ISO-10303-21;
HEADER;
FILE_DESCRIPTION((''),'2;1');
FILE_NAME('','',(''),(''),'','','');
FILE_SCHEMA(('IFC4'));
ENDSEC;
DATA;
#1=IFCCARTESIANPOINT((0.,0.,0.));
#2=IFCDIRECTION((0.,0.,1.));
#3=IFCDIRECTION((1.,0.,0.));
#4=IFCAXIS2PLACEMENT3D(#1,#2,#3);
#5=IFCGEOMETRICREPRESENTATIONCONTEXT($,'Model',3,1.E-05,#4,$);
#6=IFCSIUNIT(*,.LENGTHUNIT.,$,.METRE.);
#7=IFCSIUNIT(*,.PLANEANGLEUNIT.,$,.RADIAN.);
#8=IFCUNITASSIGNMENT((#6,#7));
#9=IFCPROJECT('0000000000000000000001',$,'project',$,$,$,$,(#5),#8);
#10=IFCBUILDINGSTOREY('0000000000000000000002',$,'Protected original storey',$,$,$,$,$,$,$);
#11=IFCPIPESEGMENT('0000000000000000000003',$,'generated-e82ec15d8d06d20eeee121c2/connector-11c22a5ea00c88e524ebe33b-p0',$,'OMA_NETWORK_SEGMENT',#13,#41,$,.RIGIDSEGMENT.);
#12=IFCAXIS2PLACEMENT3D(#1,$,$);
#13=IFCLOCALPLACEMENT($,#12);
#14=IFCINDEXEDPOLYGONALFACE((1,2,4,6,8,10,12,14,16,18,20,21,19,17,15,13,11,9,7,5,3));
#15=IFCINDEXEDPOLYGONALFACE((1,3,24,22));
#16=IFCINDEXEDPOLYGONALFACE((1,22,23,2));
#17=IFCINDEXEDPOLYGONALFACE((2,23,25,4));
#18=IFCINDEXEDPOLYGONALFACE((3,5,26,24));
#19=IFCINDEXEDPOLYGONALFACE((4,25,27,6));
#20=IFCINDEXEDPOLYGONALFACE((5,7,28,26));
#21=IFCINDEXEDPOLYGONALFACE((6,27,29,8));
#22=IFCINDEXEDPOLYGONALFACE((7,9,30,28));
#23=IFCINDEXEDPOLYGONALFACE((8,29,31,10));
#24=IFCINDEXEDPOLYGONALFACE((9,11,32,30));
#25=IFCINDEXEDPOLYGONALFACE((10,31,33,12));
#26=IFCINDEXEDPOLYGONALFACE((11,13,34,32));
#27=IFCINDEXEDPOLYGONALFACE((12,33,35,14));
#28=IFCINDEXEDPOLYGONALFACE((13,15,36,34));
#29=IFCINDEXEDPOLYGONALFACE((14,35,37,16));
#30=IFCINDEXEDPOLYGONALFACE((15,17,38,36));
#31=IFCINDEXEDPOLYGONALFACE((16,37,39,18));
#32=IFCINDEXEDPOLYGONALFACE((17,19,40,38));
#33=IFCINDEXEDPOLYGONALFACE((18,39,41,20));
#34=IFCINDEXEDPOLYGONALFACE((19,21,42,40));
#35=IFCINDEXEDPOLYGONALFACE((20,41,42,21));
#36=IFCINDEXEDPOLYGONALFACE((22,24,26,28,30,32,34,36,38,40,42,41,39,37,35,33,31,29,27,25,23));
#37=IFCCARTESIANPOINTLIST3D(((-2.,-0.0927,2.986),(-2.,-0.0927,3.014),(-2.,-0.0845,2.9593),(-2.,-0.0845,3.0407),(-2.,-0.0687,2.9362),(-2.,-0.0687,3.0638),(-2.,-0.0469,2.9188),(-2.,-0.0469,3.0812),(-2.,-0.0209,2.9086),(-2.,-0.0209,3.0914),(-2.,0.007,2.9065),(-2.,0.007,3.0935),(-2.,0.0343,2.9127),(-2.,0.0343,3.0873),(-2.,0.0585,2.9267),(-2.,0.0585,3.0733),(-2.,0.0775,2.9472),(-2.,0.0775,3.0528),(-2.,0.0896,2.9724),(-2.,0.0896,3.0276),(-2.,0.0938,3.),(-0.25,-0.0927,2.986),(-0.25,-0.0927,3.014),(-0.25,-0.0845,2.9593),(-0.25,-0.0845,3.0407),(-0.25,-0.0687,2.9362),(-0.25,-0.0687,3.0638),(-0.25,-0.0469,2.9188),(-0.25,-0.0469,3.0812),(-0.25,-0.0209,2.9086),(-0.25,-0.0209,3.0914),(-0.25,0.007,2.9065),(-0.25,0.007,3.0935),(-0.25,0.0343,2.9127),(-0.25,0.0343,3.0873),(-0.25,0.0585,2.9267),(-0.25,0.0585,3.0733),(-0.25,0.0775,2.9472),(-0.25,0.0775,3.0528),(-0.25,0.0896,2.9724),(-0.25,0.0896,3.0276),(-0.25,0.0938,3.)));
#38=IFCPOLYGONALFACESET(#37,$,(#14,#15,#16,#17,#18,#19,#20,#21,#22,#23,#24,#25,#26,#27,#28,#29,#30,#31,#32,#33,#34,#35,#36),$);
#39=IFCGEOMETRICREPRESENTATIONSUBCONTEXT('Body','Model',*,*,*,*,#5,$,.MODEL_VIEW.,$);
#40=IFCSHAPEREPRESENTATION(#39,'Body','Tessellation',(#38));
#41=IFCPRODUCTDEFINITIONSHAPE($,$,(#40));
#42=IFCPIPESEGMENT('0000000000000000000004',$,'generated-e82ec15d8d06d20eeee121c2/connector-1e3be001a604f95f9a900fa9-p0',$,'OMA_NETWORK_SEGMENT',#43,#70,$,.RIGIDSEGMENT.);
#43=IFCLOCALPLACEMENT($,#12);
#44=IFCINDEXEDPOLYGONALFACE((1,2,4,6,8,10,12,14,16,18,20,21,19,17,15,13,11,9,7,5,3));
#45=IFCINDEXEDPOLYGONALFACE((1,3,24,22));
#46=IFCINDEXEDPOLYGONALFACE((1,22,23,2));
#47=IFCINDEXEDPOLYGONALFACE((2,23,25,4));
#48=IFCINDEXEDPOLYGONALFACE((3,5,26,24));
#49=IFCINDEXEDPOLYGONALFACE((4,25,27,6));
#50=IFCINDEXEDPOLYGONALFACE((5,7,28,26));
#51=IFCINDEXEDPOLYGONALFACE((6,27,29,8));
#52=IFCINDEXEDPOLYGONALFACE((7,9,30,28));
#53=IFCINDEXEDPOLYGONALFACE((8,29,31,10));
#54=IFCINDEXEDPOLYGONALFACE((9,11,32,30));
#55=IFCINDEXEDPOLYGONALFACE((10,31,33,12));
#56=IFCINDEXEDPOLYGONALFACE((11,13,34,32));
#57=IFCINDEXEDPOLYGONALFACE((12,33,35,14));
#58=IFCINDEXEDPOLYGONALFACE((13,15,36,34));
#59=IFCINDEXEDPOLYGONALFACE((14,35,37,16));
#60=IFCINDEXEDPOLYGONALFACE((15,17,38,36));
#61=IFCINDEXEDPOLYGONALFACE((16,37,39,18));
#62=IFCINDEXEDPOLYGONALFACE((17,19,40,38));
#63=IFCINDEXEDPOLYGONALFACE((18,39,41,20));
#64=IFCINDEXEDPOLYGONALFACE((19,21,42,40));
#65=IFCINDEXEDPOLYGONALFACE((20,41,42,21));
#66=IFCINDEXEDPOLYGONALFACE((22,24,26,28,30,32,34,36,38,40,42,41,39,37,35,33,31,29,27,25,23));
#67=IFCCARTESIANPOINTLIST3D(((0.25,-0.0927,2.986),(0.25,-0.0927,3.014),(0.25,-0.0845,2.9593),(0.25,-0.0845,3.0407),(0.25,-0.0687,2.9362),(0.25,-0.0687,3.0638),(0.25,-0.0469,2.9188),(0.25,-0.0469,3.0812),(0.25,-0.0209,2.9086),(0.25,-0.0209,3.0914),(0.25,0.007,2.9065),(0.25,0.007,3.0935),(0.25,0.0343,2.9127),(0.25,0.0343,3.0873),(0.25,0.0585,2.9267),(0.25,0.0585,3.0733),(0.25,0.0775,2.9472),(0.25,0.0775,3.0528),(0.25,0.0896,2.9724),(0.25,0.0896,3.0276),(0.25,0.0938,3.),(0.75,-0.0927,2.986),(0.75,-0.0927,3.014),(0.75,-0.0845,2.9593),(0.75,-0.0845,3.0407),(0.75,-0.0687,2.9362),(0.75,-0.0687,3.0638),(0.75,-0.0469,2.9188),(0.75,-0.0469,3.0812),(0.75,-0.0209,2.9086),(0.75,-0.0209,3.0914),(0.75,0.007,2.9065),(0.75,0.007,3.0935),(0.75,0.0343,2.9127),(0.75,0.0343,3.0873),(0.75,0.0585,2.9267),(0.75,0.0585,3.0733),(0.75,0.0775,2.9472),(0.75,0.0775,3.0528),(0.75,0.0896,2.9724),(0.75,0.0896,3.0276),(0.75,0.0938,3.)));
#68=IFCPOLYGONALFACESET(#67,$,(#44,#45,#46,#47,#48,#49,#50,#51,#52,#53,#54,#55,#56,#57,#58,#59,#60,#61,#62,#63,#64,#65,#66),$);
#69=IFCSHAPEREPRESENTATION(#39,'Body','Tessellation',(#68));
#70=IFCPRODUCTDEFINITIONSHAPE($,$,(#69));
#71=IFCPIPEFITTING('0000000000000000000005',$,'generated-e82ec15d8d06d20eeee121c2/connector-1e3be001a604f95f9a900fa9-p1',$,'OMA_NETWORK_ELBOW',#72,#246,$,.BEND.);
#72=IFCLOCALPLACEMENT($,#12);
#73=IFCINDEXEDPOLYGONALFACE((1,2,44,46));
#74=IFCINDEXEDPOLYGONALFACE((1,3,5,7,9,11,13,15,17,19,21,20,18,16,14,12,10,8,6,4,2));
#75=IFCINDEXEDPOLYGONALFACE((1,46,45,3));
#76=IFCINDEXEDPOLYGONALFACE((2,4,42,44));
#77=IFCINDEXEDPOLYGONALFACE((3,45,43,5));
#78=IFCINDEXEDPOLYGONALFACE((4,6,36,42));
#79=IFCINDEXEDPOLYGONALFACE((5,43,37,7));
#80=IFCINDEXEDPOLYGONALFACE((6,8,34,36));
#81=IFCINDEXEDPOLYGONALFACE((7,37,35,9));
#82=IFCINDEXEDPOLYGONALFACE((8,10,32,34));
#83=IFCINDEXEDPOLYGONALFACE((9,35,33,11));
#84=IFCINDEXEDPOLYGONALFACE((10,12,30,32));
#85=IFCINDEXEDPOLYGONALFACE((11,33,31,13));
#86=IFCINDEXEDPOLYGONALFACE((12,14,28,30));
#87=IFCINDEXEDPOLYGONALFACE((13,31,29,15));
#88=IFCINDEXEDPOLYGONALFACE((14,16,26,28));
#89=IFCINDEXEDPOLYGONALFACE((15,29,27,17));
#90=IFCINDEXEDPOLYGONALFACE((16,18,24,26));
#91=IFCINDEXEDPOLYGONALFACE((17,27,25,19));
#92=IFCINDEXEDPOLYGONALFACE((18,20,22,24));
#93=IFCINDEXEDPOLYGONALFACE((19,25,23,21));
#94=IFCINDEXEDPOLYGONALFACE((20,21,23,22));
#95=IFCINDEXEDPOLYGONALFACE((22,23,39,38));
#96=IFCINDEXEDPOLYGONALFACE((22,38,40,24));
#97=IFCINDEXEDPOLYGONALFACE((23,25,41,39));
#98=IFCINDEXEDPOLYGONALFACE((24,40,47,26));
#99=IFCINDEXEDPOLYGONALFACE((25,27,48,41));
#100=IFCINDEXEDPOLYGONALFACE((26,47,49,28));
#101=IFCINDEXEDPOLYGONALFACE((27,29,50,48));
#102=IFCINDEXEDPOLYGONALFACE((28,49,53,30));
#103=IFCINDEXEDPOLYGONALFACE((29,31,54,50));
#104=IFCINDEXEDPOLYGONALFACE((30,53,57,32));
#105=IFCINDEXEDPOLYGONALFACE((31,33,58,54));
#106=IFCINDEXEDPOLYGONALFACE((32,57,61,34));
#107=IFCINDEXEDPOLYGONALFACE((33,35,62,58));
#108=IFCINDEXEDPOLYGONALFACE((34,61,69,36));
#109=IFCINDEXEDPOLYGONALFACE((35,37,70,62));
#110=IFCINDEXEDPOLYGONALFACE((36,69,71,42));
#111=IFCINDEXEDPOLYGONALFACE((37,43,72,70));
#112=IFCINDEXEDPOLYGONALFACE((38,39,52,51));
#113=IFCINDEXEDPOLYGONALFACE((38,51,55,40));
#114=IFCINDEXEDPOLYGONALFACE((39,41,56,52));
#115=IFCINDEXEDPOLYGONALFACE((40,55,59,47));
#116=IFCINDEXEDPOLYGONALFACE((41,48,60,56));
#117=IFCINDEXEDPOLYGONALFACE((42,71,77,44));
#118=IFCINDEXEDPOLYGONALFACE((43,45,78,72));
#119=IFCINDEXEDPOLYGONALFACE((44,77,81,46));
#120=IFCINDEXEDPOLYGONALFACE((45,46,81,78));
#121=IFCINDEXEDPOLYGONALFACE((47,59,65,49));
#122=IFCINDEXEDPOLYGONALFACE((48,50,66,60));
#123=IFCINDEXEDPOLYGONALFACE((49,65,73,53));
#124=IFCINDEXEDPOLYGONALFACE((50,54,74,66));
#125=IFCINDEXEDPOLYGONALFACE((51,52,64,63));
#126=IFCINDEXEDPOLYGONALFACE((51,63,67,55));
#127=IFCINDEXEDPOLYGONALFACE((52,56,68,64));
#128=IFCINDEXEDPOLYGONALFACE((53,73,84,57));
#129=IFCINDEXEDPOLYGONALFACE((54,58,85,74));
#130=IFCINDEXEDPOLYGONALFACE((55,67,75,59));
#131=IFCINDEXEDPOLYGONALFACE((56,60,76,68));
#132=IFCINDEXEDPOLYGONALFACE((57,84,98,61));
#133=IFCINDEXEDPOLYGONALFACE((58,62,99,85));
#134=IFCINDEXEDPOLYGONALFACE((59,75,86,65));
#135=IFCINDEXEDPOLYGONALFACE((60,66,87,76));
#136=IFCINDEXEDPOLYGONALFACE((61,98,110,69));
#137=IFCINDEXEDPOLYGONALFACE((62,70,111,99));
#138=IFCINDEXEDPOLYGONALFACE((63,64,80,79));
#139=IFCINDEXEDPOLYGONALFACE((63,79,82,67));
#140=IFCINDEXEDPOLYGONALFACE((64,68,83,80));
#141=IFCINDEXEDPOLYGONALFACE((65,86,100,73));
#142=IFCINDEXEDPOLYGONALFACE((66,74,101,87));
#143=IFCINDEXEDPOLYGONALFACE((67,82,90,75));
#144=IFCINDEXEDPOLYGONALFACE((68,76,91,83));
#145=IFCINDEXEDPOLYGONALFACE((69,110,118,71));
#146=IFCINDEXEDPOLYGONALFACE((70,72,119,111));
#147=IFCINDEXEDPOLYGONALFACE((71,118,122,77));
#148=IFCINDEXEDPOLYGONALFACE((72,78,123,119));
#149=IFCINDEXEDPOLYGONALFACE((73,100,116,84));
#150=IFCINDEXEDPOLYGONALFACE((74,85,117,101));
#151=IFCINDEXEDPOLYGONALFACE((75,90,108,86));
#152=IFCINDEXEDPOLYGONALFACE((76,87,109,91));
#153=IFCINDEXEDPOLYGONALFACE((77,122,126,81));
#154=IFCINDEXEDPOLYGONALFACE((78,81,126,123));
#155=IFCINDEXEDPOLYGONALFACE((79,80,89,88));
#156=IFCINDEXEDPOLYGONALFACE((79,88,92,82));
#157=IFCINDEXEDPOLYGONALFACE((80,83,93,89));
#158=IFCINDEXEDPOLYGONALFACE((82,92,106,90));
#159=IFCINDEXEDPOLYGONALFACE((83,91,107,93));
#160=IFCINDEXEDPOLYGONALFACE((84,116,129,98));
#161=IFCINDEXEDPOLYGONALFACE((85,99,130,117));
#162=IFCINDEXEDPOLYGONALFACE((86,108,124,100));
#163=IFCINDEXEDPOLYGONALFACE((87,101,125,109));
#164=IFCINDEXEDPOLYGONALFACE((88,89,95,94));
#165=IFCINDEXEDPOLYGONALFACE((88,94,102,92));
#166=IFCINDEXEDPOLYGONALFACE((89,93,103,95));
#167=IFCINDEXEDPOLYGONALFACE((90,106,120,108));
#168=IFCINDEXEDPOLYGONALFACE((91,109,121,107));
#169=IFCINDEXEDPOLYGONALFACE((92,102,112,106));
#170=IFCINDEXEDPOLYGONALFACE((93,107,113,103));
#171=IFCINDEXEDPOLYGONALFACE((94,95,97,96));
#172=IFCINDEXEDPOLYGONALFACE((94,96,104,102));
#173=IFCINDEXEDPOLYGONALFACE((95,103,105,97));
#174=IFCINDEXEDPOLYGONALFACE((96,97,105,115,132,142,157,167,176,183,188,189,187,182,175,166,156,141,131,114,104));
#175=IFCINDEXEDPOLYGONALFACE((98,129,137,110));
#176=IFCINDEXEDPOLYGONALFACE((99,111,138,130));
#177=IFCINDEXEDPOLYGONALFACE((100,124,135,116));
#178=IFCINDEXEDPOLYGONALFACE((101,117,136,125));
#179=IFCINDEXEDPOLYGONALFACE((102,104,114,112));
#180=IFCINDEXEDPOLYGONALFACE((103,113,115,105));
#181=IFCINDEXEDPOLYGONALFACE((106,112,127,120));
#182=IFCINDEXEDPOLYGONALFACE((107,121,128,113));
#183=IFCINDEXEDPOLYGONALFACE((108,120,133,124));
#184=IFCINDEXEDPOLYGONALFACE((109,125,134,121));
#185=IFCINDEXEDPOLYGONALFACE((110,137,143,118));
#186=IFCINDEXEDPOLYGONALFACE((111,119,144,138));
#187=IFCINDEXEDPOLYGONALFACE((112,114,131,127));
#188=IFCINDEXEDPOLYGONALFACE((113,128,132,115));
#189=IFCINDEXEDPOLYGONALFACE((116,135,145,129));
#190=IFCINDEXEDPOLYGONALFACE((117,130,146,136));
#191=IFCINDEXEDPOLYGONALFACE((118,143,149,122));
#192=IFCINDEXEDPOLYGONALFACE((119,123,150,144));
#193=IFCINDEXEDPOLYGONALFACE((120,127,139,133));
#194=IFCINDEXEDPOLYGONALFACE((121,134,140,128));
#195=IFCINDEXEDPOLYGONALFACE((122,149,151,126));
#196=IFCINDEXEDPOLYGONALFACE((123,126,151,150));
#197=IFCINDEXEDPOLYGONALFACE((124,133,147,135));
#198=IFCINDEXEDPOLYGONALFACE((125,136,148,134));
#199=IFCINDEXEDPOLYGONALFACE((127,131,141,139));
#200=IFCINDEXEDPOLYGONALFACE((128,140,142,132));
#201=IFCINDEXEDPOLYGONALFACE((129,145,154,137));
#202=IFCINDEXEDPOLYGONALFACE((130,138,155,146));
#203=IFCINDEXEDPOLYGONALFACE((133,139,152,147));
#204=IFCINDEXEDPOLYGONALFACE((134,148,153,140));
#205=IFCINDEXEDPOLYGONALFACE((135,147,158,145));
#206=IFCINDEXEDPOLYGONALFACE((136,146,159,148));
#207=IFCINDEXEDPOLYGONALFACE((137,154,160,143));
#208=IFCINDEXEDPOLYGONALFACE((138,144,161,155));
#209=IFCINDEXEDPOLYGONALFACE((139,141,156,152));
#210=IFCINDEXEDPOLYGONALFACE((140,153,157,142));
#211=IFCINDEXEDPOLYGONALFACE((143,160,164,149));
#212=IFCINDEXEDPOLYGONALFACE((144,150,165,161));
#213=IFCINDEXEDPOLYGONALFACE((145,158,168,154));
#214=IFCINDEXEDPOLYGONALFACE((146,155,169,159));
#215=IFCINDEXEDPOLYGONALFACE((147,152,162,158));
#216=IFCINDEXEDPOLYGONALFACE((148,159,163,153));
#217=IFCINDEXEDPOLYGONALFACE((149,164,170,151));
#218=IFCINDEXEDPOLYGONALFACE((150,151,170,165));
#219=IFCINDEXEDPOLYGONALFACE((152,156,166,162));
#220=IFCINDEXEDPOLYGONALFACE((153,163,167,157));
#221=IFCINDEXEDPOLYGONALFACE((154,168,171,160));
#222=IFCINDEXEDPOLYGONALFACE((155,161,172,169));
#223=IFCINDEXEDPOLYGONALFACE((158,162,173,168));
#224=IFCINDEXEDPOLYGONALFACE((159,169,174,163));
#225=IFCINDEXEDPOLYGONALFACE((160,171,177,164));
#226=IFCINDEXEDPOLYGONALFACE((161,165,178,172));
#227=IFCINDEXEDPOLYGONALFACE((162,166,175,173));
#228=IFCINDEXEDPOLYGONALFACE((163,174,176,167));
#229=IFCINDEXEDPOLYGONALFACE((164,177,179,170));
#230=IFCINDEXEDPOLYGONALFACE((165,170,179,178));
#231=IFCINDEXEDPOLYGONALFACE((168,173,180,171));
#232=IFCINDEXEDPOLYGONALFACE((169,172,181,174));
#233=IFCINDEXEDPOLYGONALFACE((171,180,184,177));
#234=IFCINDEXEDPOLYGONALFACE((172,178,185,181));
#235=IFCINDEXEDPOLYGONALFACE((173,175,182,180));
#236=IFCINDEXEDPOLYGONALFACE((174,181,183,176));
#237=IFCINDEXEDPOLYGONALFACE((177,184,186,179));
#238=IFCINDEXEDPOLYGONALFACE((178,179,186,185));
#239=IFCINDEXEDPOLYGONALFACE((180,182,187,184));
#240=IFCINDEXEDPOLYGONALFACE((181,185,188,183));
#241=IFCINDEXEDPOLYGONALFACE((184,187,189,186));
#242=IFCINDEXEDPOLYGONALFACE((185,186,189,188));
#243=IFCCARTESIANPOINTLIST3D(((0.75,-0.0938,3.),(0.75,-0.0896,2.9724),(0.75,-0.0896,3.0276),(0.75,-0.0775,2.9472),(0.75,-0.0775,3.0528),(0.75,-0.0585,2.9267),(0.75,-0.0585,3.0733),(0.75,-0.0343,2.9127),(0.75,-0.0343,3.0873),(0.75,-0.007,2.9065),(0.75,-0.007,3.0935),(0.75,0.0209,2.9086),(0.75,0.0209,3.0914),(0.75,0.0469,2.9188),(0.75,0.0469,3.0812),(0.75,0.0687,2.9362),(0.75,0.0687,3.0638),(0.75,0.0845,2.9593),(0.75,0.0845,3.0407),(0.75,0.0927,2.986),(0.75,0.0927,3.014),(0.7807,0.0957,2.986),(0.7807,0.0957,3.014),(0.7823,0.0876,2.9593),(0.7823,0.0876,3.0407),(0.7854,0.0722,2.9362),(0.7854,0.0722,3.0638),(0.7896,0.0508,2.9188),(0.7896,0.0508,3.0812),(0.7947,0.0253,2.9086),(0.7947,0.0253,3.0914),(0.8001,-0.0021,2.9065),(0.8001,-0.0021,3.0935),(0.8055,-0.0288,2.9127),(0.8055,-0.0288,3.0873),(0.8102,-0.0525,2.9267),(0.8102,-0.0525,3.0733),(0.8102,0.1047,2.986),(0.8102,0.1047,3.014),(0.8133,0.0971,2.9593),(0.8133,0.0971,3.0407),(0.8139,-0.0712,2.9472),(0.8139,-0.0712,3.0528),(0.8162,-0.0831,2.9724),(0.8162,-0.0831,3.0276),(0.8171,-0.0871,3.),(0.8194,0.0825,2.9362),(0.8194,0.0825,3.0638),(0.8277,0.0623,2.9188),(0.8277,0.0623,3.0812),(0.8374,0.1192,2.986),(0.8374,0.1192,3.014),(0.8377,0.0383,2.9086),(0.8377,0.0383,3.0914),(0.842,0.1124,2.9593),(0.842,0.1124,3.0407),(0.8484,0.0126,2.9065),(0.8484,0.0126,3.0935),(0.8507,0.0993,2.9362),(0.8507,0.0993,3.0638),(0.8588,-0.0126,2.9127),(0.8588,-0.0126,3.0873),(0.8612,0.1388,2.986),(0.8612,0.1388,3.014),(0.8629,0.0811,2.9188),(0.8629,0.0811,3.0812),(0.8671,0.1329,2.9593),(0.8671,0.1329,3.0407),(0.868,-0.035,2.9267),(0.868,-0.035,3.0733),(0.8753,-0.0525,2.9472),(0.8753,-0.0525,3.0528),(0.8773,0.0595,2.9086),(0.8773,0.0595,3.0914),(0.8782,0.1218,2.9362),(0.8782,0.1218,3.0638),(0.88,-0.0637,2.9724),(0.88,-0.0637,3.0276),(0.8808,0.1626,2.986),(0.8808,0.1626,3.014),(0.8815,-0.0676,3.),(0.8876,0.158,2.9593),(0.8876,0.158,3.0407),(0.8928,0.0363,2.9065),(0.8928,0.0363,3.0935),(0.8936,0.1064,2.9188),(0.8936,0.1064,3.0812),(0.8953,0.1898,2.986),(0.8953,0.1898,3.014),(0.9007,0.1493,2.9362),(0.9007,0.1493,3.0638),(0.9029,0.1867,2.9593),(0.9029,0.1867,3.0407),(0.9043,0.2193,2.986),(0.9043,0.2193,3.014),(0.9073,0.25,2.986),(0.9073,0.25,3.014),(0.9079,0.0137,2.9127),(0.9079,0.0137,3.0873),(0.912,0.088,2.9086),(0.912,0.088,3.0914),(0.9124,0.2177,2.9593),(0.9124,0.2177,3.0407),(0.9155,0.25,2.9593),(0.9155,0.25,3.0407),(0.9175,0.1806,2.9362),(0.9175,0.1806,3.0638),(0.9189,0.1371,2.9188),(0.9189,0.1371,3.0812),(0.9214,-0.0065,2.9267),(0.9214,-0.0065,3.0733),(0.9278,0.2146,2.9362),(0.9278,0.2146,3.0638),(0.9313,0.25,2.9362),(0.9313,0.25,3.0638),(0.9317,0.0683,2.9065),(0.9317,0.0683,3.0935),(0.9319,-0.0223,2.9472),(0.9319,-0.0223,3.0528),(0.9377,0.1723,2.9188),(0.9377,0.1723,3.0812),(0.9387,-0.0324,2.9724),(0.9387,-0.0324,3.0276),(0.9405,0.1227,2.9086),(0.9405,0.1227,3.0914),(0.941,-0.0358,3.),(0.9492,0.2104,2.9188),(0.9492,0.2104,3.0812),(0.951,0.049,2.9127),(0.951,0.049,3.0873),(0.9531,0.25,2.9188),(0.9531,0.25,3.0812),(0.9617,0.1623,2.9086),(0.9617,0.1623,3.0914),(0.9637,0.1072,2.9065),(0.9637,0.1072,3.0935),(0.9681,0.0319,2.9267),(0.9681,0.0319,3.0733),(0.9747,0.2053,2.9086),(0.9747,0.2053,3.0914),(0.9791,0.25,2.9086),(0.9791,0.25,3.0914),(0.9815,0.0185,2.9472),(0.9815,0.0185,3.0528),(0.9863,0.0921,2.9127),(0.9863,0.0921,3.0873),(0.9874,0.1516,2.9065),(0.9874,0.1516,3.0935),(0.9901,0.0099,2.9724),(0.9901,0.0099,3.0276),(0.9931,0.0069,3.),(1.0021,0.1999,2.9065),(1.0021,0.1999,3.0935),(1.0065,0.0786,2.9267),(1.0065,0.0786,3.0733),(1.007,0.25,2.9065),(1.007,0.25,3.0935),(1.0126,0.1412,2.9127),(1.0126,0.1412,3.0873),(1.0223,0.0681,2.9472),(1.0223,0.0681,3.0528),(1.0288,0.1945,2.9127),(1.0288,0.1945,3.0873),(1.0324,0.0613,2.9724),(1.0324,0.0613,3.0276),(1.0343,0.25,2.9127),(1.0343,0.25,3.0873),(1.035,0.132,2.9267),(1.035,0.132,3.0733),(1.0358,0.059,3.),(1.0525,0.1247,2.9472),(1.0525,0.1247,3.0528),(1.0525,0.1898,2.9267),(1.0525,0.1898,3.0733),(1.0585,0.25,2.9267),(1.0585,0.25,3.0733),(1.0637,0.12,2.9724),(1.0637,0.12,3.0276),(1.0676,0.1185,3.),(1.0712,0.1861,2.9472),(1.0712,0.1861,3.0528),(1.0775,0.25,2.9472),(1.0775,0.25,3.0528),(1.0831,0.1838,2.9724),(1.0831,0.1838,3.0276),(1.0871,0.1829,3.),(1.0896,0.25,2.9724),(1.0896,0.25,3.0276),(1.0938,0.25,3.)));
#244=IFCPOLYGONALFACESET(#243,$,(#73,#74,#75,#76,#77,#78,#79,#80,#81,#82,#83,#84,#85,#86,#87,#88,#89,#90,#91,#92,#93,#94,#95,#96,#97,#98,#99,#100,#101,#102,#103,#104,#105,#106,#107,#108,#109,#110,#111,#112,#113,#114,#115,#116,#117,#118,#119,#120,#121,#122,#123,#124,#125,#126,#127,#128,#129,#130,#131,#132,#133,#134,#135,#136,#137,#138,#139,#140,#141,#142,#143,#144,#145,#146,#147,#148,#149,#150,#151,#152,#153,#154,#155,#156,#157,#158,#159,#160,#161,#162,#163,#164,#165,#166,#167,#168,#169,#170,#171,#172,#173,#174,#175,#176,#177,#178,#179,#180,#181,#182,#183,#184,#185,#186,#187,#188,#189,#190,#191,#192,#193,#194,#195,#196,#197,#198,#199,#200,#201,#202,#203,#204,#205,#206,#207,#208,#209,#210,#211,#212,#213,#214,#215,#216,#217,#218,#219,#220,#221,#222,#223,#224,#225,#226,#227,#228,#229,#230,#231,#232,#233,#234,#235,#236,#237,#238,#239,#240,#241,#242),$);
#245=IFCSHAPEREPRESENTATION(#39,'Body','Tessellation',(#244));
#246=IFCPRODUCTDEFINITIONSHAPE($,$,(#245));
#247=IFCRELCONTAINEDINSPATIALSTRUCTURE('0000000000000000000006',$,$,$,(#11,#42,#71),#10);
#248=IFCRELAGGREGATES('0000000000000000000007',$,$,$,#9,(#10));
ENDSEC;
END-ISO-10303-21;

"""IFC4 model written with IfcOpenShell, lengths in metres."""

from ifc_helpers import new_model, entity, si_unit, frame, origin_with_axes, origin_2d, place, context, subcontext, project, spatial, circle, extrude, element, save


model = new_model("IFC4")

# Units and contexts
model_context = context("Model", 3, precision=1e-05, world=origin_with_axes())
body_context = subcontext(model_context, "Body", "Model", "MODEL_VIEW")
ifc_project = project(units=[si_unit("LENGTHUNIT", "METRE"), si_unit("PLANEANGLEUNIT", "RADIAN")], contexts=[model_context])

# Storey
storey = spatial("IfcBuildingStorey", under=ifc_project, Name="Protected original storey")

# Pipe segments
pipe_segment_1_placement = place(None, origin_with_axes())
element("IfcPipeSegment", 1, at=pipe_segment_1_placement, inside=storey, Name="generated-e82ec15d8d06d20eeee121c2/connector-11c22a5ea00c88e524ebe33b-p0", ObjectType="OMA_NETWORK_SEGMENT", PredefinedType="RIGIDSEGMENT", context=body_context, shape_type="SweptSolid", body=[
    extrude(circle(Radius=0.0938, at=origin_2d()), frame((-2.0, 0.0, 3.0), z_axis=(1.0, 0.0, 0.0), x_axis=(0.0, 1.0, 0.0)), (0.0, 0.0, 1.0), 1.75),
])
pipe_segment_2_placement = place(None, origin_with_axes())
element("IfcPipeSegment", 2, at=pipe_segment_2_placement, inside=storey, Name="generated-e82ec15d8d06d20eeee121c2/connector-1e3be001a604f95f9a900fa9-p0", ObjectType="OMA_NETWORK_SEGMENT", PredefinedType="RIGIDSEGMENT", context=body_context, shape_type="SweptSolid", body=[
    extrude(circle(Radius=0.0938, at=origin_2d()), frame((0.25, 0.0, 3.0), z_axis=(1.0, 0.0, 0.0), x_axis=(0.0, 1.0, 0.0)), (0.0, 0.0, 1.0), 0.5),
])

# Pipe fitting
pipe_fitting_1_placement = place(None, origin_with_axes())
element("IfcPipeFitting", 3, at=pipe_fitting_1_placement, inside=storey, Name="generated-e82ec15d8d06d20eeee121c2/connector-1e3be001a604f95f9a900fa9-p1", ObjectType="OMA_NETWORK_ELBOW", PredefinedType="BEND", context=body_context, shape_type="SweptSolid", body=[
    entity("IfcRevolvedAreaSolid", entity("IfcCircleProfileDef", "AREA", None, entity("IfcAxis2Placement2D", entity("IfcCartesianPoint", [0.25, 0.0])), 0.0938), entity("IfcAxis2Placement3D", entity("IfcCartesianPoint", [0.75, 0.25, 3.0]), entity("IfcDirection", [1.0, 0.0, 0.0]), entity("IfcDirection", [0.0, -1.0, 0.0])), entity("IfcAxis1Placement", entity("IfcCartesianPoint", [0.0, 0.0, 0.0]), entity("IfcDirection", [0.0, -1.0, 0.0])), 1.570796),
])

save(model, "model.ifc")
